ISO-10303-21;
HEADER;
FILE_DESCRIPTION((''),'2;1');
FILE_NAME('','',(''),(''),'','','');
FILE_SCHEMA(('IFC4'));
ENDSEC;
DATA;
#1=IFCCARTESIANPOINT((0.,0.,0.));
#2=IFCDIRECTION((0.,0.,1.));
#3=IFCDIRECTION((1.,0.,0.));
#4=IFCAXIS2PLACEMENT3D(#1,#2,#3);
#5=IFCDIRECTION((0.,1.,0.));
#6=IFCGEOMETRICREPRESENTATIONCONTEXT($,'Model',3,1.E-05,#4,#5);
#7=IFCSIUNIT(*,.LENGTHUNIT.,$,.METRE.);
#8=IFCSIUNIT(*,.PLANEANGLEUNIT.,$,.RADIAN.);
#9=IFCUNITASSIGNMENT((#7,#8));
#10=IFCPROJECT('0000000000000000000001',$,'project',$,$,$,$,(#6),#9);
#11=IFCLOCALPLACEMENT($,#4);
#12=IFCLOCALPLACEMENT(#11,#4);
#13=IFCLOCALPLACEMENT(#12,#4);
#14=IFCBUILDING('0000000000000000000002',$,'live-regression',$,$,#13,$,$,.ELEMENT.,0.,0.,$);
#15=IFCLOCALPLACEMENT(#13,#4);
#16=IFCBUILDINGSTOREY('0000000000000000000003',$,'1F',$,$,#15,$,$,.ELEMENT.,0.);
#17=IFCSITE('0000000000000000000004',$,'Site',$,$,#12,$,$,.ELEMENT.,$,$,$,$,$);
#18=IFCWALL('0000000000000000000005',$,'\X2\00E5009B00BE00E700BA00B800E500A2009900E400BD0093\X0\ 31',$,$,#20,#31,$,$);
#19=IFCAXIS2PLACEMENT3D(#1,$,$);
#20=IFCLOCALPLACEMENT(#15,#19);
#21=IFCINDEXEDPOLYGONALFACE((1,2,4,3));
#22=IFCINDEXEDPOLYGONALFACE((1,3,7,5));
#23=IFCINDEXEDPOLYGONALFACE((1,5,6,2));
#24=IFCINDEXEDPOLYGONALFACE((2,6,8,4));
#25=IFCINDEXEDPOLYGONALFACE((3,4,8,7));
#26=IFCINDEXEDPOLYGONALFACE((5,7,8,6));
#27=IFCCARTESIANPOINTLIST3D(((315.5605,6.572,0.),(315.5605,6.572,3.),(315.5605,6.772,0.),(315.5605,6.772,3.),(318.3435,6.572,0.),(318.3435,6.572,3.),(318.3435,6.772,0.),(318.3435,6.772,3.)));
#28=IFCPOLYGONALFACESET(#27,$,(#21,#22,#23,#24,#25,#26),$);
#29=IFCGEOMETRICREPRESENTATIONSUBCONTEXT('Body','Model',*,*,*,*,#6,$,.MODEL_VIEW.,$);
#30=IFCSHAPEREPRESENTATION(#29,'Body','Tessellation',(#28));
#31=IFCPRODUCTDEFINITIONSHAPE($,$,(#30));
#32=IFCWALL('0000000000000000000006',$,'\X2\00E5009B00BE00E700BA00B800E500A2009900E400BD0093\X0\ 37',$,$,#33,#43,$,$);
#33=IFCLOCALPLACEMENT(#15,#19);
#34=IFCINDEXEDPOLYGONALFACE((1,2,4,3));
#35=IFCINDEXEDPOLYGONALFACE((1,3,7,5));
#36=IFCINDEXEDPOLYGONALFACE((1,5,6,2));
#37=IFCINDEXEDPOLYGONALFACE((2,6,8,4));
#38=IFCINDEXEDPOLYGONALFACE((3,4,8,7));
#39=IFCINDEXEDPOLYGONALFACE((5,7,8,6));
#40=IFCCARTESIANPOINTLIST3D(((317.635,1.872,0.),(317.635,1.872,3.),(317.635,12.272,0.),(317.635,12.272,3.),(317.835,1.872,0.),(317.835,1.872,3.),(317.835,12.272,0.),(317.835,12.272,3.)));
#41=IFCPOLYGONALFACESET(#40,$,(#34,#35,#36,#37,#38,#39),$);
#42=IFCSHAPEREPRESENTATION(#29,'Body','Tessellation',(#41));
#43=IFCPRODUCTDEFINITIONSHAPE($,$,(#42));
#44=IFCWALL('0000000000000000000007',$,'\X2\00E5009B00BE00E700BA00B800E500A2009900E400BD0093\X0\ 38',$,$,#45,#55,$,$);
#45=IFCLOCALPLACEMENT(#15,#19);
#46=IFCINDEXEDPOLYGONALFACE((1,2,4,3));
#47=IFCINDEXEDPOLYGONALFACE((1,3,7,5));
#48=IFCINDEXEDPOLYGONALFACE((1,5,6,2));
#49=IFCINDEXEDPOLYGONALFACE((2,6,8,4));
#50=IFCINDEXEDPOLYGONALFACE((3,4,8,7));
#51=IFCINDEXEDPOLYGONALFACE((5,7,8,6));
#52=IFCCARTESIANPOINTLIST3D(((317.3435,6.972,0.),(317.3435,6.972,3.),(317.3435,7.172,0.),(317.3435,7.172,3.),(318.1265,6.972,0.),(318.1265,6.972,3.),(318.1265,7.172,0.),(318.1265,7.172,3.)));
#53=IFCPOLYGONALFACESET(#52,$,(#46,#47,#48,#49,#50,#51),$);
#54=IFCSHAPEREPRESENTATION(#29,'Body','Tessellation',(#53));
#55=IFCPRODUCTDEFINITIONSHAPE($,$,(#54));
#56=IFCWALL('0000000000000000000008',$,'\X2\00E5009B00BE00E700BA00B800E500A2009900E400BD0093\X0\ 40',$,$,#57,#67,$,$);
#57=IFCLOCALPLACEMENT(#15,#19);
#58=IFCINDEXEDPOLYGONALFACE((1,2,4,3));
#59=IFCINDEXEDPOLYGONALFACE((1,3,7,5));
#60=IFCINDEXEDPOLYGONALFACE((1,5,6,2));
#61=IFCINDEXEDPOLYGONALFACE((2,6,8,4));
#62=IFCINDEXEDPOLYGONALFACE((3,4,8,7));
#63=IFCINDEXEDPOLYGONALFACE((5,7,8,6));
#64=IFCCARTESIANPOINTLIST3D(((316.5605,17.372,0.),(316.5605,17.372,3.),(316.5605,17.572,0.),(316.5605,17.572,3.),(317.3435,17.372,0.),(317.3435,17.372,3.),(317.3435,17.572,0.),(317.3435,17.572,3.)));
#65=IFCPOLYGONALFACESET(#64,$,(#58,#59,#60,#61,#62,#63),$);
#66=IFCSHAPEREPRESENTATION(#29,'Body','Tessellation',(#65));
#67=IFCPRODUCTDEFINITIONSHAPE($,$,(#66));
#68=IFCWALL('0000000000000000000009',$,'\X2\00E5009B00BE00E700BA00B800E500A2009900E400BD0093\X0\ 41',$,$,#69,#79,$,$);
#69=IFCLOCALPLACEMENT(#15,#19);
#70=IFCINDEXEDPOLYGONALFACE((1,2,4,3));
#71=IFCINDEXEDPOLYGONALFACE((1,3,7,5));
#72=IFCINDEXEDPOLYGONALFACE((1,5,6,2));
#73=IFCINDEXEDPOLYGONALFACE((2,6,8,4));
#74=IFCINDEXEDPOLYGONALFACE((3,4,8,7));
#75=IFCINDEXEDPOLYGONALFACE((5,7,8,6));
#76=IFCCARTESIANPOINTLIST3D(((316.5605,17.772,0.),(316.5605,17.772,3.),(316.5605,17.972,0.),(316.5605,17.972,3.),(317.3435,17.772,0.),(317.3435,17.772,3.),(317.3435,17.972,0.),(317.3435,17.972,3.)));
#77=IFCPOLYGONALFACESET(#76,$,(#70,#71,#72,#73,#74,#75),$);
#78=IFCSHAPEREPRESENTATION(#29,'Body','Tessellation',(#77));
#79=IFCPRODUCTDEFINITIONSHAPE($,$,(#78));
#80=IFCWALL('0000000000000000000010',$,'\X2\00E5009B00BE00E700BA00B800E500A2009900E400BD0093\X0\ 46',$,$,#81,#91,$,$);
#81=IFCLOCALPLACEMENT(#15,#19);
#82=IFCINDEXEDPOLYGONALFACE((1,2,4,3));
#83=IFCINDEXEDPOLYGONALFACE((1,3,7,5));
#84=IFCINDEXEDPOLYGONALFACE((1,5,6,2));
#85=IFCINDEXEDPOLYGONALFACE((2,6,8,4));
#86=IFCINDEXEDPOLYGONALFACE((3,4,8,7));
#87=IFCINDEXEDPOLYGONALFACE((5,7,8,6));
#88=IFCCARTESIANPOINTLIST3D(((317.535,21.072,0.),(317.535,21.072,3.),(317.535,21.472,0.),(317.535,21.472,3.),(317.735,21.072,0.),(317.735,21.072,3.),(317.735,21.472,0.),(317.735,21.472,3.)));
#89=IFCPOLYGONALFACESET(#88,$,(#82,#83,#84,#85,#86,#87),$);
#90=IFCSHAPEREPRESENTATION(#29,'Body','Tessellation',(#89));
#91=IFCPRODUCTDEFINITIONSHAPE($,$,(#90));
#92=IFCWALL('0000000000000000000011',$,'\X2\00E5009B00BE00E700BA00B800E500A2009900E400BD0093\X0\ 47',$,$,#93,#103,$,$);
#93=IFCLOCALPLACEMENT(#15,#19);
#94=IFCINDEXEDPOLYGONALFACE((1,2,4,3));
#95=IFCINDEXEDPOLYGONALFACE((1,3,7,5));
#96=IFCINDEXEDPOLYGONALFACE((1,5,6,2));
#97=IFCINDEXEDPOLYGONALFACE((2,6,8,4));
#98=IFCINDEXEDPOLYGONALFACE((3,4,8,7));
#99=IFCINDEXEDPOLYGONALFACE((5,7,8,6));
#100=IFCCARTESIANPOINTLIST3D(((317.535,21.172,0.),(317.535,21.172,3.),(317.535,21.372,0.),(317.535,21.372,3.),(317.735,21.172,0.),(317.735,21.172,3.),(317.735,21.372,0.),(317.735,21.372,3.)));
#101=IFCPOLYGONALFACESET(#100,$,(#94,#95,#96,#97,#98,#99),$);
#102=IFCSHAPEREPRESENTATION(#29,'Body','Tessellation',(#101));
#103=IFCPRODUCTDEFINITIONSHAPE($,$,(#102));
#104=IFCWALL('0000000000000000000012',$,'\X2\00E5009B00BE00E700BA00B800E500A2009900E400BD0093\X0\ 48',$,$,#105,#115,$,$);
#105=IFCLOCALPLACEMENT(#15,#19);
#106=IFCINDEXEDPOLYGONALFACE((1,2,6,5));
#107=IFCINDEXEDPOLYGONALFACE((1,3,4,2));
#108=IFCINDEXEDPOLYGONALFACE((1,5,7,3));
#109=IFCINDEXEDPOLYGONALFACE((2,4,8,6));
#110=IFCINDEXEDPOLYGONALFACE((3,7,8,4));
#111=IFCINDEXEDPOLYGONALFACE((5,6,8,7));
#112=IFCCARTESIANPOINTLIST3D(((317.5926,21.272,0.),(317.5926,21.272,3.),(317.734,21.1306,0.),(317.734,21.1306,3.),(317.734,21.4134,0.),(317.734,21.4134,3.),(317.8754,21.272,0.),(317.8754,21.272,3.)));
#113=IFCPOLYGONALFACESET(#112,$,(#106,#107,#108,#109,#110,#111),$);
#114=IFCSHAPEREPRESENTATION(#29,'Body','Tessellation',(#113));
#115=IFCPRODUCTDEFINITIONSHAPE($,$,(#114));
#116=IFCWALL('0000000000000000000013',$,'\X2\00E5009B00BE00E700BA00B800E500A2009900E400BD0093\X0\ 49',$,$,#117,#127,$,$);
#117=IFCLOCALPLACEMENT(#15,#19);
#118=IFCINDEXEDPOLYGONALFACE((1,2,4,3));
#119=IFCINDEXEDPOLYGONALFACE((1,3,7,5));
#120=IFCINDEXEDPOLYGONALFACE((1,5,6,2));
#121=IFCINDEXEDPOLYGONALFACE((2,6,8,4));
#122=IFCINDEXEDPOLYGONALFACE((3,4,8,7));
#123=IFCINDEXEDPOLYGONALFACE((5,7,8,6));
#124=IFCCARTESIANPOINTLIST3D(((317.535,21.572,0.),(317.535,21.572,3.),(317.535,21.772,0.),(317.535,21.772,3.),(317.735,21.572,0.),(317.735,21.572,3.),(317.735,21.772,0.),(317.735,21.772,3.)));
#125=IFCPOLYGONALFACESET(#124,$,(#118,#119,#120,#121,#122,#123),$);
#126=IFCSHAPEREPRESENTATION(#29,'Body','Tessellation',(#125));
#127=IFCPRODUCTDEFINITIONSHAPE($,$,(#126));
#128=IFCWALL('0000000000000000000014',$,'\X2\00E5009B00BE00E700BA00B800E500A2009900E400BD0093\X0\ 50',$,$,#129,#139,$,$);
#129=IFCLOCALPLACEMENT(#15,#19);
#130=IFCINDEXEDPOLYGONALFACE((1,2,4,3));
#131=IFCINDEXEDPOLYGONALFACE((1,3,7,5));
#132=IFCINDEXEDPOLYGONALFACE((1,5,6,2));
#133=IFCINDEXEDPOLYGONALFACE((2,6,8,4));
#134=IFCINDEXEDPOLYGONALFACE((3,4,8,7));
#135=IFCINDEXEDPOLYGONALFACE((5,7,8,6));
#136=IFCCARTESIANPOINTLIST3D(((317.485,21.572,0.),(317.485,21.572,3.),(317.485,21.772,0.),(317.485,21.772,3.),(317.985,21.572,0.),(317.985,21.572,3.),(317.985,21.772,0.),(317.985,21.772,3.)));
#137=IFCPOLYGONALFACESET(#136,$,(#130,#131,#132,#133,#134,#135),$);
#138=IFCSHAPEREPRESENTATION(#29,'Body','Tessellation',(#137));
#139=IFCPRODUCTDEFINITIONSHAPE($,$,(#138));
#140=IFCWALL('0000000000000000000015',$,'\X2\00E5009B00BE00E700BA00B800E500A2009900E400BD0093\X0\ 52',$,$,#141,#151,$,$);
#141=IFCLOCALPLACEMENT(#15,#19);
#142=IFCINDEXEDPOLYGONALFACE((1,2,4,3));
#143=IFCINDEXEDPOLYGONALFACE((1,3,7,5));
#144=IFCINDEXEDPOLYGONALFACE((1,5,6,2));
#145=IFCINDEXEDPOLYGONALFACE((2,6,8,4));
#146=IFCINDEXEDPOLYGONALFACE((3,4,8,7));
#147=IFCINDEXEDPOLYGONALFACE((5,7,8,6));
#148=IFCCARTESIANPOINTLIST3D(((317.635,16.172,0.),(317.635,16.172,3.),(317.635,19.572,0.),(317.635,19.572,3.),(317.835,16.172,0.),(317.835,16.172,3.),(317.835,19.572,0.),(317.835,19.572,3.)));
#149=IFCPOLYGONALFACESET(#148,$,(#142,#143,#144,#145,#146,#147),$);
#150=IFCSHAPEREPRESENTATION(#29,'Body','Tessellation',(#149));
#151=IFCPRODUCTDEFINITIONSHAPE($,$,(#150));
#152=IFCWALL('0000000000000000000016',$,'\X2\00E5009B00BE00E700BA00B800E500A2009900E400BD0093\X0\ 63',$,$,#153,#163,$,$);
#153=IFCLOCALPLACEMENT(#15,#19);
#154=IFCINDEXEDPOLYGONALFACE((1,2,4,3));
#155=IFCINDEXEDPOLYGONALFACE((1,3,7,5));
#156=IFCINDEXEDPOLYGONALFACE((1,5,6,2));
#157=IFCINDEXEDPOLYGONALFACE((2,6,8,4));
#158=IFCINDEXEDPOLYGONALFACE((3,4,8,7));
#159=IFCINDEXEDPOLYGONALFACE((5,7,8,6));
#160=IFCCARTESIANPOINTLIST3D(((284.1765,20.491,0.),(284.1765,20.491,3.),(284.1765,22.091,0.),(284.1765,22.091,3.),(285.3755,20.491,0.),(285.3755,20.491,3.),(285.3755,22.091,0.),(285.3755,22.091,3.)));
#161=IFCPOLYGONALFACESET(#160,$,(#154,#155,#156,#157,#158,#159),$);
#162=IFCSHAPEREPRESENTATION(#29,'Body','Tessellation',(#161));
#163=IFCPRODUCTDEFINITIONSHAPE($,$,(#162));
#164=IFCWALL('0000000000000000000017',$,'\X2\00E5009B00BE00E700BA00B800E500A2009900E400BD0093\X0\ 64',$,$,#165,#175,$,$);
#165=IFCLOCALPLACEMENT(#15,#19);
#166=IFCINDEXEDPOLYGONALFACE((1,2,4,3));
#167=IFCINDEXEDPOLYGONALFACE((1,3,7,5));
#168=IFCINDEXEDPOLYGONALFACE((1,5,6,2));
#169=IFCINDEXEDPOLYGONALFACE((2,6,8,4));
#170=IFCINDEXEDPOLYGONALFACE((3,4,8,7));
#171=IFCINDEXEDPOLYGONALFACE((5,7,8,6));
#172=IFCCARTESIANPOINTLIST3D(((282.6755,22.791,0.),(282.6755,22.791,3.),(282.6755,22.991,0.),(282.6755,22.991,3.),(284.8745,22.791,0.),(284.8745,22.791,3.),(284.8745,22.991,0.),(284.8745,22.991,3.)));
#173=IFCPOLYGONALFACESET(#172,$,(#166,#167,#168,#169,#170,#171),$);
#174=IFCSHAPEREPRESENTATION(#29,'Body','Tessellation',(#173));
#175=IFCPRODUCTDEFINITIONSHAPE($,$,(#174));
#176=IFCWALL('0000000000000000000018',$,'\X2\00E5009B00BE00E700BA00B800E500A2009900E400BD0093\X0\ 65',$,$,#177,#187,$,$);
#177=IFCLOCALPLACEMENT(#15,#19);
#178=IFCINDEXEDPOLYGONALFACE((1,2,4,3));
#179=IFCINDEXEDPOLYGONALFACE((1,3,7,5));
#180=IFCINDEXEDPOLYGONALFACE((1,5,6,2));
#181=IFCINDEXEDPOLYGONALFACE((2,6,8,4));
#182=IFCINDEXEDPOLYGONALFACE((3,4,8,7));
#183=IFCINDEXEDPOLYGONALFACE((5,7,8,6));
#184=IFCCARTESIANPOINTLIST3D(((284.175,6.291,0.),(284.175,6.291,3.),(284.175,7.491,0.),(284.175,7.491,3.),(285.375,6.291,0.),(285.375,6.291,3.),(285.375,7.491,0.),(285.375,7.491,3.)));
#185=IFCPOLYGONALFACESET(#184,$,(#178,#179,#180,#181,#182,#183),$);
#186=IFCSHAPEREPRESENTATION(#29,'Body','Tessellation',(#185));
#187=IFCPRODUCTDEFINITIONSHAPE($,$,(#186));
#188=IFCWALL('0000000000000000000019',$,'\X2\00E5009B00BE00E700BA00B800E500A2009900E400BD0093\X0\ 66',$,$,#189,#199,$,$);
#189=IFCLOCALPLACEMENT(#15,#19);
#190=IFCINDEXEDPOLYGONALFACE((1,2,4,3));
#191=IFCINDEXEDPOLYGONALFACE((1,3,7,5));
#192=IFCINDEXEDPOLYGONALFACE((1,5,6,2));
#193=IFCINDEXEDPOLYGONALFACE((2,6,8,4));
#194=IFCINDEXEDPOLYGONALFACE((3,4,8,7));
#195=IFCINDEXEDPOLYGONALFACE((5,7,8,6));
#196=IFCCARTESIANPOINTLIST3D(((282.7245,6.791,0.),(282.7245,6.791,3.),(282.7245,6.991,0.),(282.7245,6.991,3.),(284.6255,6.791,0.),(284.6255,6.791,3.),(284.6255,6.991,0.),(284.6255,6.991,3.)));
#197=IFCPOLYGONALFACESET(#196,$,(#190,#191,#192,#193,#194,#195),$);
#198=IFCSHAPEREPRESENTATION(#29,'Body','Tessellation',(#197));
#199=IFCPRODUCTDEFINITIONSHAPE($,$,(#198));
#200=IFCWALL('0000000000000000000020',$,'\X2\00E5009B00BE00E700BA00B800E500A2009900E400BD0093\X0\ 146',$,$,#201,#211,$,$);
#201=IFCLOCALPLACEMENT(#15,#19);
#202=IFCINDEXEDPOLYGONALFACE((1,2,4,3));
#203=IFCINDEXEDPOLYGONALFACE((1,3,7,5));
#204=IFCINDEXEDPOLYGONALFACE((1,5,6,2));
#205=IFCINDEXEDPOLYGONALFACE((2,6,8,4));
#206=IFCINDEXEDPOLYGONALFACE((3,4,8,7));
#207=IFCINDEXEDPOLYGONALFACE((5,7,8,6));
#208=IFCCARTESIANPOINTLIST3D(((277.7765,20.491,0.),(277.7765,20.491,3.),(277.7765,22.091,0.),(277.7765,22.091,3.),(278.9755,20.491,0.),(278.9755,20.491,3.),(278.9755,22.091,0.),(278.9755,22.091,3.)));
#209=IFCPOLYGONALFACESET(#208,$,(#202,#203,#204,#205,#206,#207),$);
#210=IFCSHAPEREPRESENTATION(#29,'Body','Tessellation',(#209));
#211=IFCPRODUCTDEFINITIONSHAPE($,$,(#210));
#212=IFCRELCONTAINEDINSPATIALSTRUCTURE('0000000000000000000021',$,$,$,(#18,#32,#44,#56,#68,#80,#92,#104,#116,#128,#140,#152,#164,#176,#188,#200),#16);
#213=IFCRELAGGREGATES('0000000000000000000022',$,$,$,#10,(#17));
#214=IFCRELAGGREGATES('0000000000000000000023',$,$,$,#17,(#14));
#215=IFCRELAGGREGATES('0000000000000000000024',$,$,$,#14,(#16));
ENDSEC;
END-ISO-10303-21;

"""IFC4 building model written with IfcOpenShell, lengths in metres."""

from ifc_helpers import new_model, si_unit, direction, frame, frame_2d, origin_with_axes, place, context, subcontext, project, spatial, rectangle, extrude, element, save


model = new_model("IFC4")

# Units and contexts
model_context = context("Model", 3, precision=1e-05, world=origin_with_axes(), true_north=direction((0.0, 1.0, 0.0)))
body_context = subcontext(model_context, "Body", "Model", "MODEL_VIEW")
ifc_project = project(units=[si_unit("LENGTHUNIT", "METRE"), si_unit("PLANEANGLEUNIT", "RADIAN")], contexts=[model_context])

# Site, building, storey
placement = place(None, origin_with_axes())
site_placement = place(placement, origin_with_axes())
site = spatial("IfcSite", under=ifc_project, at=site_placement, Name="Site", CompositionType="ELEMENT")
building_placement = place(site_placement, origin_with_axes())
building = spatial("IfcBuilding", under=site, at=building_placement, Name="live-regression", CompositionType="ELEMENT", ElevationOfRefHeight=0.0, ElevationOfTerrain=0.0)
storey_placement = place(building_placement, origin_with_axes())
storey = spatial("IfcBuildingStorey", under=building, at=storey_placement, Name="1F", CompositionType="ELEMENT", Elevation=0.0)

# Walls
wall_1_placement = place(storey_placement, frame((316.952, 6.672, 0.0), z_axis=(0.0, 0.0, 1.0), x_axis=(1.0, 0.0, 0.0)))
element("IfcWall", 1, at=wall_1_placement, inside=storey, Name="å\u009b¾çº¸å¢\u0099ä½\u0093 31", context=body_context, shape_type="SweptSolid", body=[
    extrude(rectangle(XDim=2.783, YDim=0.2, at=frame_2d((0.0, 0.0), x_axis=(1.0, 0.0, 0.0))), frame((0.0, 0.0, 0.0), z_axis=(0.0, 0.0, 1.0)), (0.0, 0.0, 1.0), 3.0),
])
wall_2_placement = place(storey_placement, frame((317.735, 7.072, 0.0), z_axis=(0.0, 0.0, 1.0), x_axis=(0.0, 1.0, 0.0)))
element("IfcWall", 2, at=wall_2_placement, inside=storey, Name="å\u009b¾çº¸å¢\u0099ä½\u0093 37", context=body_context, shape_type="SweptSolid", body=[
    extrude(rectangle(XDim=10.4, YDim=0.2, at=frame_2d((0.0, 0.0), x_axis=(1.0, 0.0, 0.0))), frame((0.0, 0.0, 0.0), z_axis=(0.0, 0.0, 1.0)), (0.0, 0.0, 1.0), 3.0),
])
for number, where, z_axis, x_axis, name in (
    (3, (317.735, 7.072, 0.0), (0.0, 0.0, 1.0), (-1.0, 0.0, 0.0), "å\u009b¾çº¸å¢\u0099ä½\u0093 38"),
    (4, (316.952, 17.472, 0.0), (0.0, 0.0, 1.0), (1.0, 0.0, 0.0), "å\u009b¾çº¸å¢\u0099ä½\u0093 40"),
    (5, (316.952, 17.872, 0.0), (0.0, 0.0, 1.0), (1.0, 0.0, 0.0), "å\u009b¾çº¸å¢\u0099ä½\u0093 41"),
):
    element("IfcWall", number, at=place(storey_placement, frame(where, z_axis=z_axis, x_axis=x_axis)), inside=storey, Name=name, context=body_context, shape_type="SweptSolid", body=[
        extrude(rectangle(XDim=0.783, YDim=0.2, at=frame_2d((0.0, 0.0), x_axis=(1.0, 0.0, 0.0))), frame((0.0, 0.0, 0.0), z_axis=(0.0, 0.0, 1.0)), (0.0, 0.0, 1.0), 3.0),
    ])
wall_3_placement = place(storey_placement, frame((317.635, 21.272, 0.0), z_axis=(0.0, 0.0, 1.0), x_axis=(0.0, 1.0, 0.0)))
element("IfcWall", 6, at=wall_3_placement, inside=storey, Name="å\u009b¾çº¸å¢\u0099ä½\u0093 46", context=body_context, shape_type="SweptSolid", body=[
    extrude(rectangle(XDim=0.4, YDim=0.2, at=frame_2d((0.0, 0.0), x_axis=(1.0, 0.0, 0.0))), frame((0.0, 0.0, 0.0), z_axis=(0.0, 0.0, 1.0)), (0.0, 0.0, 1.0), 3.0),
])
for number, where, z_axis, x_axis, name in (
    (7, (317.635, 21.272, 0.0), (0.0, 0.0, 1.0), (1.0, 0.0, 0.0), "å\u009b¾çº¸å¢\u0099ä½\u0093 47"),
    (8, (317.734, 21.272, 0.0), (0.0, 0.0, 1.0), (0.707107, -0.707107, 0.0), "å\u009b¾çº¸å¢\u0099ä½\u0093 48"),
    (9, (317.635, 21.672, 0.0), (0.0, 0.0, 1.0), (1.0, 0.0, 0.0), "å\u009b¾çº¸å¢\u0099ä½\u0093 49"),
):
    element("IfcWall", number, at=place(storey_placement, frame(where, z_axis=z_axis, x_axis=x_axis)), inside=storey, Name=name, context=body_context, shape_type="SweptSolid", body=[
        extrude(rectangle(XDim=0.2, YDim=0.2, at=frame_2d((0.0, 0.0), x_axis=(1.0, 0.0, 0.0))), frame((0.0, 0.0, 0.0), z_axis=(0.0, 0.0, 1.0)), (0.0, 0.0, 1.0), 3.0),
    ])
wall_4_placement = place(storey_placement, frame((317.735, 21.672, 0.0), z_axis=(0.0, 0.0, 1.0), x_axis=(1.0, 0.0, 0.0)))
element("IfcWall", 10, at=wall_4_placement, inside=storey, Name="å\u009b¾çº¸å¢\u0099ä½\u0093 50", context=body_context, shape_type="SweptSolid", body=[
    extrude(rectangle(XDim=0.5, YDim=0.2, at=frame_2d((0.0, 0.0), x_axis=(1.0, 0.0, 0.0))), frame((0.0, 0.0, 0.0), z_axis=(0.0, 0.0, 1.0)), (0.0, 0.0, 1.0), 3.0),
])
wall_5_placement = place(storey_placement, frame((317.735, 17.872, 0.0), z_axis=(0.0, 0.0, 1.0), x_axis=(0.0, 1.0, 0.0)))
element("IfcWall", 11, at=wall_5_placement, inside=storey, Name="å\u009b¾çº¸å¢\u0099ä½\u0093 52", context=body_context, shape_type="SweptSolid", body=[
    extrude(rectangle(XDim=3.4, YDim=0.2, at=frame_2d((0.0, 0.0), x_axis=(1.0, 0.0, 0.0))), frame((0.0, 0.0, 0.0), z_axis=(0.0, 0.0, 1.0)), (0.0, 0.0, 1.0), 3.0),
])
wall_6_placement = place(storey_placement, frame((284.776, 21.291, 0.0), z_axis=(0.0, 0.0, 1.0), x_axis=(1.0, 0.0, 0.0)))
element("IfcWall", 12, at=wall_6_placement, inside=storey, Name="å\u009b¾çº¸å¢\u0099ä½\u0093 63", context=body_context, shape_type="SweptSolid", body=[
    extrude(rectangle(XDim=1.199, YDim=1.6, at=frame_2d((0.0, 0.0), x_axis=(1.0, 0.0, 0.0))), frame((0.0, 0.0, 0.0), z_axis=(0.0, 0.0, 1.0)), (0.0, 0.0, 1.0), 3.0),
])
wall_7_placement = place(storey_placement, frame((283.775, 22.891, 0.0), z_axis=(0.0, 0.0, 1.0), x_axis=(1.0, 0.0, 0.0)))
element("IfcWall", 13, at=wall_7_placement, inside=storey, Name="å\u009b¾çº¸å¢\u0099ä½\u0093 64", context=body_context, shape_type="SweptSolid", body=[
    extrude(rectangle(XDim=2.199, YDim=0.2, at=frame_2d((0.0, 0.0), x_axis=(1.0, 0.0, 0.0))), frame((0.0, 0.0, 0.0), z_axis=(0.0, 0.0, 1.0)), (0.0, 0.0, 1.0), 3.0),
])
wall_8_placement = place(storey_placement, frame((284.775, 6.891, 0.0), z_axis=(0.0, 0.0, 1.0), x_axis=(1.0, 0.0, 0.0)))
element("IfcWall", 14, at=wall_8_placement, inside=storey, Name="å\u009b¾çº¸å¢\u0099ä½\u0093 65", context=body_context, shape_type="SweptSolid", body=[
    extrude(rectangle(XDim=1.2, YDim=1.2, at=frame_2d((0.0, 0.0), x_axis=(1.0, 0.0, 0.0))), frame((0.0, 0.0, 0.0), z_axis=(0.0, 0.0, 1.0)), (0.0, 0.0, 1.0), 3.0),
])
wall_9_placement = place(storey_placement, frame((283.675, 6.891, 0.0), z_axis=(0.0, 0.0, 1.0), x_axis=(1.0, 0.0, 0.0)))
element("IfcWall", 15, at=wall_9_placement, inside=storey, Name="å\u009b¾çº¸å¢\u0099ä½\u0093 66", context=body_context, shape_type="SweptSolid", body=[
    extrude(rectangle(XDim=1.901, YDim=0.2, at=frame_2d((0.0, 0.0), x_axis=(1.0, 0.0, 0.0))), frame((0.0, 0.0, 0.0), z_axis=(0.0, 0.0, 1.0)), (0.0, 0.0, 1.0), 3.0),
])
wall_10_placement = place(storey_placement, frame((278.376, 21.291, 0.0), z_axis=(0.0, 0.0, 1.0), x_axis=(1.0, 0.0, 0.0)))
element("IfcWall", 16, at=wall_10_placement, inside=storey, Name="å\u009b¾çº¸å¢\u0099ä½\u0093 146", context=body_context, shape_type="SweptSolid", body=[
    extrude(rectangle(XDim=1.199, YDim=1.6, at=frame_2d((0.0, 0.0), x_axis=(1.0, 0.0, 0.0))), frame((0.0, 0.0, 0.0), z_axis=(0.0, 0.0, 1.0)), (0.0, 0.0, 1.0), 3.0),
])

save(model, "model.ifc")
